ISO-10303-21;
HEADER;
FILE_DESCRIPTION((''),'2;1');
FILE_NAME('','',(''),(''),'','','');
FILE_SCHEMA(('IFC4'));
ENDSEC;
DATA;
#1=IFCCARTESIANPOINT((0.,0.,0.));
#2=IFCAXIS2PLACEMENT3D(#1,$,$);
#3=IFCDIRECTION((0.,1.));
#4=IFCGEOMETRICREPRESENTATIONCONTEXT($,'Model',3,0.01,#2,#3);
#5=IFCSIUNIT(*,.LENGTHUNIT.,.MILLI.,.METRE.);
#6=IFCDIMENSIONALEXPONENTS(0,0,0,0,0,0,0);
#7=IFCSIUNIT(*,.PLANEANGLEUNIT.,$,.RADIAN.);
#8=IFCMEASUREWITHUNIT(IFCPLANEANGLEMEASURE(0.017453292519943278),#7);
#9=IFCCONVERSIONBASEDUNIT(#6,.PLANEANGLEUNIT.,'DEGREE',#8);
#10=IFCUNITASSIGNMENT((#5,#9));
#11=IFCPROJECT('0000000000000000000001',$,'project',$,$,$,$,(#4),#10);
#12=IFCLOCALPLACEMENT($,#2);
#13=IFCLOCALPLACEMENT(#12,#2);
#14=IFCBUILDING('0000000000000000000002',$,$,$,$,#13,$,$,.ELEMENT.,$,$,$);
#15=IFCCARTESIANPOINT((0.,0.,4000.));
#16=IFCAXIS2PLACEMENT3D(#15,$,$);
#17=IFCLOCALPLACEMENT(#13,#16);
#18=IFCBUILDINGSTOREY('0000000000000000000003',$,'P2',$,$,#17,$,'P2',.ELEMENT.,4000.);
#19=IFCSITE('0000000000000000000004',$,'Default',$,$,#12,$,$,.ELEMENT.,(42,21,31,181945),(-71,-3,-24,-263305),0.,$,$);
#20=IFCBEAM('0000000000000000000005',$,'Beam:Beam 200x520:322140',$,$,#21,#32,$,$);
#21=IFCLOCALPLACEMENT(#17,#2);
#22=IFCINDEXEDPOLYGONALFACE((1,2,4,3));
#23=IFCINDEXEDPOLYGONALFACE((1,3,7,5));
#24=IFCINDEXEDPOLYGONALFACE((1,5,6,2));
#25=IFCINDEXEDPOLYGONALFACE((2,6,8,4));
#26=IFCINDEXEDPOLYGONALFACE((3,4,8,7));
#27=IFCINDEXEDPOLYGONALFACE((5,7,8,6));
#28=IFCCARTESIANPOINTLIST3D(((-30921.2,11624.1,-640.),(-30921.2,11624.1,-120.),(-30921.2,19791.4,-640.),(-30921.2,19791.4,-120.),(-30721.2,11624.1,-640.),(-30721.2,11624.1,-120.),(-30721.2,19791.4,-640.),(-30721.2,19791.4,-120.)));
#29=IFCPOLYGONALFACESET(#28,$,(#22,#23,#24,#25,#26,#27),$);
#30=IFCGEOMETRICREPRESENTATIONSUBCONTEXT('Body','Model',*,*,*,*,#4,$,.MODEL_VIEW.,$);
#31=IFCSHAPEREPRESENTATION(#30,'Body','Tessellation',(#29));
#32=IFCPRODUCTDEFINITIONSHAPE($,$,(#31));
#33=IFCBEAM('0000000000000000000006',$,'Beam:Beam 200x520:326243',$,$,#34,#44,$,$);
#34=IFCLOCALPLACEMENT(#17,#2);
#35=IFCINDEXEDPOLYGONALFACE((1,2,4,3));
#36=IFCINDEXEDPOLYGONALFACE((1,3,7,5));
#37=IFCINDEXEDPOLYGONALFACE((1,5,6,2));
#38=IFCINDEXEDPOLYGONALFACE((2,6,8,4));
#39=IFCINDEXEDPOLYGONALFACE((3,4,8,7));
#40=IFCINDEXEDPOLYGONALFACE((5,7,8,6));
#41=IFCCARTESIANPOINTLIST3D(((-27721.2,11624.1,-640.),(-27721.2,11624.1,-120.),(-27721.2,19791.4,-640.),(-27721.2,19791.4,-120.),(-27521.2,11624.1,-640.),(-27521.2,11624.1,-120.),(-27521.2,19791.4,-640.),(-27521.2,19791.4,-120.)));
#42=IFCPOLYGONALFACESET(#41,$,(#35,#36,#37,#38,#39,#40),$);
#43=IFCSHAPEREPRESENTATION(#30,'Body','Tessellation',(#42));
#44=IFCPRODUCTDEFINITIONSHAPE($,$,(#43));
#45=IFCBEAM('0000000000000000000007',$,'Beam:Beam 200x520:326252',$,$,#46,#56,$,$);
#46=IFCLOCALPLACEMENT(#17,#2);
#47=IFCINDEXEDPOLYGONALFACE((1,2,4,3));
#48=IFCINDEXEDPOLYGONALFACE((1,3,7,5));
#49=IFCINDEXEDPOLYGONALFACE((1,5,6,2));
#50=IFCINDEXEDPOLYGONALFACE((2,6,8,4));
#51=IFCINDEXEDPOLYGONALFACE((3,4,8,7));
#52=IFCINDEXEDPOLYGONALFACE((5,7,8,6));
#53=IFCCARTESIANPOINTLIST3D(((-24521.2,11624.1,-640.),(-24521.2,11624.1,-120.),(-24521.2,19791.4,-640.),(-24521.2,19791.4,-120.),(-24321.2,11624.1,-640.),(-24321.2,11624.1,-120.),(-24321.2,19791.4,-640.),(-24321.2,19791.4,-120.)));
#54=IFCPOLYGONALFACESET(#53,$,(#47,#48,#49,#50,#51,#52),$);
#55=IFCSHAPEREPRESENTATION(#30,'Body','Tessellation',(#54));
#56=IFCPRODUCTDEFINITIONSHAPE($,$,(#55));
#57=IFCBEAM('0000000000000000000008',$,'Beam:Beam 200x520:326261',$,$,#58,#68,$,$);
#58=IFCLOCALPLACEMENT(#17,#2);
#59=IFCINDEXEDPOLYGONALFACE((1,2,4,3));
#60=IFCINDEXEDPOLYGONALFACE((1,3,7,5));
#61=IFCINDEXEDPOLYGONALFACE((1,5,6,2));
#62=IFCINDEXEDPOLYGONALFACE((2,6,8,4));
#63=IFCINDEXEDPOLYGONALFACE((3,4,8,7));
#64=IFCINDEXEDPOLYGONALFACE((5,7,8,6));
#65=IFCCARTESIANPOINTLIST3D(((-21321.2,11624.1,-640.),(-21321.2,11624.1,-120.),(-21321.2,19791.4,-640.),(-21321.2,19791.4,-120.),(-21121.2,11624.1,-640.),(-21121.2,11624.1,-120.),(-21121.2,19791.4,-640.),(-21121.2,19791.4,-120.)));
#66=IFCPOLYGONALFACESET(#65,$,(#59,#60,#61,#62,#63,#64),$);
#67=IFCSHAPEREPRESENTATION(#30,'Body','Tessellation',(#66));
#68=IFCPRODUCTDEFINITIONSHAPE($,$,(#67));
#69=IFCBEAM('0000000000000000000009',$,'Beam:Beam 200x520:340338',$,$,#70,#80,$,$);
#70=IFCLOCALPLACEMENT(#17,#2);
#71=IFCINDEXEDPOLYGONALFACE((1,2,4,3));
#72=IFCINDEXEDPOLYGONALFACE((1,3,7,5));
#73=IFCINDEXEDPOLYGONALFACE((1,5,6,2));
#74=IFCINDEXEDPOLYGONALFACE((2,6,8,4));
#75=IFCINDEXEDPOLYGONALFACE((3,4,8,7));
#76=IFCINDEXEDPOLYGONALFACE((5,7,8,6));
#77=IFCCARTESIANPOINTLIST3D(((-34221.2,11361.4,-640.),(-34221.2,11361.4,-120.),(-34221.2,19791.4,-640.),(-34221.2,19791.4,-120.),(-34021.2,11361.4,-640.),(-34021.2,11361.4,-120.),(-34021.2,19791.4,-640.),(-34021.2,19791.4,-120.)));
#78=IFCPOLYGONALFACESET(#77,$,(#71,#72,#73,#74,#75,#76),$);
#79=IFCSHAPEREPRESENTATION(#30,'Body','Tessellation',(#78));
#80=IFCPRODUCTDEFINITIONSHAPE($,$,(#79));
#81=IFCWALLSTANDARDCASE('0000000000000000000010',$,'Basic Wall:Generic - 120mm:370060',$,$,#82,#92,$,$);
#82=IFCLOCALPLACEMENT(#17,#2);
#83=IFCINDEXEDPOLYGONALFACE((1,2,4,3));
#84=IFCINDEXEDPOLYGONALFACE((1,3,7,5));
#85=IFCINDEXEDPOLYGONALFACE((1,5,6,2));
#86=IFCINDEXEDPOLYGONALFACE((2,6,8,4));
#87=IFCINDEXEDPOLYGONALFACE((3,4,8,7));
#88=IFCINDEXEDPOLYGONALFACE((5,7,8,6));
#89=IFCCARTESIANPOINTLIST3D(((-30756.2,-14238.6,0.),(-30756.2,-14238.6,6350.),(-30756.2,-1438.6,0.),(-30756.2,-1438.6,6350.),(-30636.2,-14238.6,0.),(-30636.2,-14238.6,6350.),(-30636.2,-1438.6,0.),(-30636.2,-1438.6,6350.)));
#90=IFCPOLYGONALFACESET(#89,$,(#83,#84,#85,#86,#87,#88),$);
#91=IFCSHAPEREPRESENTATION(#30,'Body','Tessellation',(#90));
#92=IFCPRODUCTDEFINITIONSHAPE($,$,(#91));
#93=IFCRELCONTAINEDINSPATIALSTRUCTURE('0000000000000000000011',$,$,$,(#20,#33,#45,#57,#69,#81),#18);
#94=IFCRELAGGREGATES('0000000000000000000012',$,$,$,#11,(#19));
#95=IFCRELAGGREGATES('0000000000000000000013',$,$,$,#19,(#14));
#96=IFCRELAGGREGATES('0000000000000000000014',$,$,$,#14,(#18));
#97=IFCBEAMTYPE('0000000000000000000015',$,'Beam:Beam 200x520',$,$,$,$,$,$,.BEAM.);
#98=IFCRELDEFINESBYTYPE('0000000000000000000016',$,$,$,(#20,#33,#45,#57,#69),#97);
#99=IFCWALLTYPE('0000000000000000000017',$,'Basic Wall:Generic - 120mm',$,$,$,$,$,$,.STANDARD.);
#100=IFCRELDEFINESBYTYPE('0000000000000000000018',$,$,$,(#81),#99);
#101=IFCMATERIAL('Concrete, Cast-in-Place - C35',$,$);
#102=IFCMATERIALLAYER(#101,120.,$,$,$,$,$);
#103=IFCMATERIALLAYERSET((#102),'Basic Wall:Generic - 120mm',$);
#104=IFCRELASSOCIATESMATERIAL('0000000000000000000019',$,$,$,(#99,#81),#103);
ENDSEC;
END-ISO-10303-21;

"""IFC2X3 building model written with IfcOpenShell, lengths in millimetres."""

from ifc_helpers import new_model, entity, si_unit, converted_unit, direction, frame, frame_2d, origin, place, context, subcontext, project, spatial, rectangle, extrude, material, layer, layer_set, layer_usage, type_object, element, save


model = new_model("IFC2X3")

# Units and contexts
model_context = context("Model", 3, precision=0.01, world=origin(), true_north=direction((0.0, 1.0)))
body_context = subcontext(model_context, "Body", "Model", "MODEL_VIEW")
ifc_project = project(units=[si_unit("LENGTHUNIT", "METRE", prefix="MILLI"), converted_unit("PLANEANGLEUNIT", "DEGREE", entity("IfcPlaneAngleMeasure", 0.017453292519943278), si_unit("PLANEANGLEUNIT", "RADIAN"), dimensions=[0, 0, 0, 0, 0, 0, 0])], contexts=[model_context])

# Site, building, storey
site_placement = place(None, origin())
site = spatial("IfcSite", under=ifc_project, at=site_placement, Name="Default", CompositionType="ELEMENT", RefLatitude=(42, 21, 31, 181945), RefLongitude=(-71, -3, -24, -263305), RefElevation=0.0)
building_placement = place(site_placement, origin())
building = spatial("IfcBuilding", under=site, at=building_placement, CompositionType="ELEMENT")
storey_placement = place(building_placement, frame((0.0, 0.0, 4000.0)))
storey = spatial("IfcBuildingStorey", under=building, at=storey_placement, Name="P2", LongName="P2", CompositionType="ELEMENT", Elevation=4000.0)

# Shared definitions
ifc_material = material(Name="Concrete, Cast-in-Place - C35")

# Beams
beam_type_1 = type_object("IfcBeamType", Name="Beam:Beam 200x520", PredefinedType="BEAM")
beam_1_placement = place(storey_placement, frame((-30846.2, 19791.4, -120.0), z_axis=(0.0, 0.0, 1.0), x_axis=(0.0, -1.0, 0.0)))
element("IfcBeam", 1, at=beam_1_placement, inside=storey, type_object=beam_type_1, Name="Beam:Beam 200x520:322140", context=body_context, shape_type="SweptSolid", body=[
    extrude(rectangle(XDim=520.0, YDim=200.0, at=frame_2d((0.0, 0.0), x_axis=(1.0, 0.0))), frame((0.0, 25.0, -260.0), z_axis=(1.0, 0.0, 0.0), x_axis=(0.0, 0.0, -1.0)), (0.0, 0.0, 1.0), 8167.3),
])
beam_2_placement = place(storey_placement, frame((-27646.2, 19791.4, -120.0), z_axis=(0.0, 0.0, 1.0), x_axis=(0.0, -1.0, 0.0)))
element("IfcBeam", 2, at=beam_2_placement, inside=storey, type_object=beam_type_1, Name="Beam:Beam 200x520:326243", context=body_context, shape_type="SweptSolid", body=[
    extrude(rectangle(XDim=520.0, YDim=200.0, at=frame_2d((0.0, 0.0), x_axis=(1.0, 0.0))), frame((0.0, 25.0, -260.0), z_axis=(1.0, 0.0, 0.0), x_axis=(0.0, 0.0, -1.0)), (0.0, 0.0, 1.0), 8167.3),
])
beam_3_placement = place(storey_placement, frame((-24446.2, 19791.4, -120.0), z_axis=(0.0, 0.0, 1.0), x_axis=(0.0, -1.0, 0.0)))
element("IfcBeam", 3, at=beam_3_placement, inside=storey, type_object=beam_type_1, Name="Beam:Beam 200x520:326252", context=body_context, shape_type="SweptSolid", body=[
    extrude(rectangle(XDim=520.0, YDim=200.0, at=frame_2d((0.0, 0.0), x_axis=(1.0, 0.0))), frame((0.0, 25.0, -260.0), z_axis=(1.0, 0.0, 0.0), x_axis=(0.0, 0.0, -1.0)), (0.0, 0.0, 1.0), 8167.3),
])
beam_4_placement = place(storey_placement, frame((-21246.2, 19791.4, -120.0), z_axis=(0.0, 0.0, 1.0), x_axis=(0.0, -1.0, 0.0)))
element("IfcBeam", 4, at=beam_4_placement, inside=storey, type_object=beam_type_1, Name="Beam:Beam 200x520:326261", context=body_context, shape_type="SweptSolid", body=[
    extrude(rectangle(XDim=520.0, YDim=200.0, at=frame_2d((0.0, 0.0), x_axis=(1.0, 0.0))), frame((0.0, 25.0, -260.0), z_axis=(1.0, 0.0, 0.0), x_axis=(0.0, 0.0, -1.0)), (0.0, 0.0, 1.0), 8167.3),
])
beam_5_placement = place(storey_placement, frame((-34146.2, 19791.4, -120.0), z_axis=(0.0, 0.0, 1.0), x_axis=(0.0, -1.0, 0.0)))
element("IfcBeam", 5, at=beam_5_placement, inside=storey, type_object=beam_type_1, Name="Beam:Beam 200x520:340338", context=body_context, shape_type="SweptSolid", body=[
    extrude(rectangle(XDim=520.0, YDim=200.0, at=frame_2d((0.0, 0.0), x_axis=(1.0, 0.0))), frame((0.0, 25.0, -260.0), z_axis=(1.0, 0.0, 0.0), x_axis=(0.0, 0.0, -1.0)), (0.0, 0.0, 1.0), 8430.0),
])

# Wall
ifc_layer = layer(ifc_material, 120.0)
ifc_layer_set = layer_set([ifc_layer], Name="Basic Wall:Generic - 120mm")
ifc_layer_usage = layer_usage(ifc_layer_set, "AXIS2", "NEGATIVE", 60.0)
wall_type = type_object("IfcWallType", Name="Basic Wall:Generic - 120mm", PredefinedType="STANDARD", material=ifc_layer_set)
wall_placement = place(storey_placement, frame((-30696.2, -1438.6, 0.0), z_axis=(0.0, 0.0, 1.0), x_axis=(0.0, -1.0, 0.0)))
element("IfcWallStandardCase", 6, at=wall_placement, inside=storey, type_object=wall_type, material=ifc_layer_usage, Name="Basic Wall:Generic - 120mm:370060", context=body_context, shape_type="SweptSolid", body=[
    extrude(rectangle(XDim=12800.0, YDim=120.0, at=frame_2d((6400.0, 0.0), x_axis=(-1.0, 0.0))), origin(), (0.0, 0.0, 1.0), 6350.0),
])

save(model, "model.ifc")
